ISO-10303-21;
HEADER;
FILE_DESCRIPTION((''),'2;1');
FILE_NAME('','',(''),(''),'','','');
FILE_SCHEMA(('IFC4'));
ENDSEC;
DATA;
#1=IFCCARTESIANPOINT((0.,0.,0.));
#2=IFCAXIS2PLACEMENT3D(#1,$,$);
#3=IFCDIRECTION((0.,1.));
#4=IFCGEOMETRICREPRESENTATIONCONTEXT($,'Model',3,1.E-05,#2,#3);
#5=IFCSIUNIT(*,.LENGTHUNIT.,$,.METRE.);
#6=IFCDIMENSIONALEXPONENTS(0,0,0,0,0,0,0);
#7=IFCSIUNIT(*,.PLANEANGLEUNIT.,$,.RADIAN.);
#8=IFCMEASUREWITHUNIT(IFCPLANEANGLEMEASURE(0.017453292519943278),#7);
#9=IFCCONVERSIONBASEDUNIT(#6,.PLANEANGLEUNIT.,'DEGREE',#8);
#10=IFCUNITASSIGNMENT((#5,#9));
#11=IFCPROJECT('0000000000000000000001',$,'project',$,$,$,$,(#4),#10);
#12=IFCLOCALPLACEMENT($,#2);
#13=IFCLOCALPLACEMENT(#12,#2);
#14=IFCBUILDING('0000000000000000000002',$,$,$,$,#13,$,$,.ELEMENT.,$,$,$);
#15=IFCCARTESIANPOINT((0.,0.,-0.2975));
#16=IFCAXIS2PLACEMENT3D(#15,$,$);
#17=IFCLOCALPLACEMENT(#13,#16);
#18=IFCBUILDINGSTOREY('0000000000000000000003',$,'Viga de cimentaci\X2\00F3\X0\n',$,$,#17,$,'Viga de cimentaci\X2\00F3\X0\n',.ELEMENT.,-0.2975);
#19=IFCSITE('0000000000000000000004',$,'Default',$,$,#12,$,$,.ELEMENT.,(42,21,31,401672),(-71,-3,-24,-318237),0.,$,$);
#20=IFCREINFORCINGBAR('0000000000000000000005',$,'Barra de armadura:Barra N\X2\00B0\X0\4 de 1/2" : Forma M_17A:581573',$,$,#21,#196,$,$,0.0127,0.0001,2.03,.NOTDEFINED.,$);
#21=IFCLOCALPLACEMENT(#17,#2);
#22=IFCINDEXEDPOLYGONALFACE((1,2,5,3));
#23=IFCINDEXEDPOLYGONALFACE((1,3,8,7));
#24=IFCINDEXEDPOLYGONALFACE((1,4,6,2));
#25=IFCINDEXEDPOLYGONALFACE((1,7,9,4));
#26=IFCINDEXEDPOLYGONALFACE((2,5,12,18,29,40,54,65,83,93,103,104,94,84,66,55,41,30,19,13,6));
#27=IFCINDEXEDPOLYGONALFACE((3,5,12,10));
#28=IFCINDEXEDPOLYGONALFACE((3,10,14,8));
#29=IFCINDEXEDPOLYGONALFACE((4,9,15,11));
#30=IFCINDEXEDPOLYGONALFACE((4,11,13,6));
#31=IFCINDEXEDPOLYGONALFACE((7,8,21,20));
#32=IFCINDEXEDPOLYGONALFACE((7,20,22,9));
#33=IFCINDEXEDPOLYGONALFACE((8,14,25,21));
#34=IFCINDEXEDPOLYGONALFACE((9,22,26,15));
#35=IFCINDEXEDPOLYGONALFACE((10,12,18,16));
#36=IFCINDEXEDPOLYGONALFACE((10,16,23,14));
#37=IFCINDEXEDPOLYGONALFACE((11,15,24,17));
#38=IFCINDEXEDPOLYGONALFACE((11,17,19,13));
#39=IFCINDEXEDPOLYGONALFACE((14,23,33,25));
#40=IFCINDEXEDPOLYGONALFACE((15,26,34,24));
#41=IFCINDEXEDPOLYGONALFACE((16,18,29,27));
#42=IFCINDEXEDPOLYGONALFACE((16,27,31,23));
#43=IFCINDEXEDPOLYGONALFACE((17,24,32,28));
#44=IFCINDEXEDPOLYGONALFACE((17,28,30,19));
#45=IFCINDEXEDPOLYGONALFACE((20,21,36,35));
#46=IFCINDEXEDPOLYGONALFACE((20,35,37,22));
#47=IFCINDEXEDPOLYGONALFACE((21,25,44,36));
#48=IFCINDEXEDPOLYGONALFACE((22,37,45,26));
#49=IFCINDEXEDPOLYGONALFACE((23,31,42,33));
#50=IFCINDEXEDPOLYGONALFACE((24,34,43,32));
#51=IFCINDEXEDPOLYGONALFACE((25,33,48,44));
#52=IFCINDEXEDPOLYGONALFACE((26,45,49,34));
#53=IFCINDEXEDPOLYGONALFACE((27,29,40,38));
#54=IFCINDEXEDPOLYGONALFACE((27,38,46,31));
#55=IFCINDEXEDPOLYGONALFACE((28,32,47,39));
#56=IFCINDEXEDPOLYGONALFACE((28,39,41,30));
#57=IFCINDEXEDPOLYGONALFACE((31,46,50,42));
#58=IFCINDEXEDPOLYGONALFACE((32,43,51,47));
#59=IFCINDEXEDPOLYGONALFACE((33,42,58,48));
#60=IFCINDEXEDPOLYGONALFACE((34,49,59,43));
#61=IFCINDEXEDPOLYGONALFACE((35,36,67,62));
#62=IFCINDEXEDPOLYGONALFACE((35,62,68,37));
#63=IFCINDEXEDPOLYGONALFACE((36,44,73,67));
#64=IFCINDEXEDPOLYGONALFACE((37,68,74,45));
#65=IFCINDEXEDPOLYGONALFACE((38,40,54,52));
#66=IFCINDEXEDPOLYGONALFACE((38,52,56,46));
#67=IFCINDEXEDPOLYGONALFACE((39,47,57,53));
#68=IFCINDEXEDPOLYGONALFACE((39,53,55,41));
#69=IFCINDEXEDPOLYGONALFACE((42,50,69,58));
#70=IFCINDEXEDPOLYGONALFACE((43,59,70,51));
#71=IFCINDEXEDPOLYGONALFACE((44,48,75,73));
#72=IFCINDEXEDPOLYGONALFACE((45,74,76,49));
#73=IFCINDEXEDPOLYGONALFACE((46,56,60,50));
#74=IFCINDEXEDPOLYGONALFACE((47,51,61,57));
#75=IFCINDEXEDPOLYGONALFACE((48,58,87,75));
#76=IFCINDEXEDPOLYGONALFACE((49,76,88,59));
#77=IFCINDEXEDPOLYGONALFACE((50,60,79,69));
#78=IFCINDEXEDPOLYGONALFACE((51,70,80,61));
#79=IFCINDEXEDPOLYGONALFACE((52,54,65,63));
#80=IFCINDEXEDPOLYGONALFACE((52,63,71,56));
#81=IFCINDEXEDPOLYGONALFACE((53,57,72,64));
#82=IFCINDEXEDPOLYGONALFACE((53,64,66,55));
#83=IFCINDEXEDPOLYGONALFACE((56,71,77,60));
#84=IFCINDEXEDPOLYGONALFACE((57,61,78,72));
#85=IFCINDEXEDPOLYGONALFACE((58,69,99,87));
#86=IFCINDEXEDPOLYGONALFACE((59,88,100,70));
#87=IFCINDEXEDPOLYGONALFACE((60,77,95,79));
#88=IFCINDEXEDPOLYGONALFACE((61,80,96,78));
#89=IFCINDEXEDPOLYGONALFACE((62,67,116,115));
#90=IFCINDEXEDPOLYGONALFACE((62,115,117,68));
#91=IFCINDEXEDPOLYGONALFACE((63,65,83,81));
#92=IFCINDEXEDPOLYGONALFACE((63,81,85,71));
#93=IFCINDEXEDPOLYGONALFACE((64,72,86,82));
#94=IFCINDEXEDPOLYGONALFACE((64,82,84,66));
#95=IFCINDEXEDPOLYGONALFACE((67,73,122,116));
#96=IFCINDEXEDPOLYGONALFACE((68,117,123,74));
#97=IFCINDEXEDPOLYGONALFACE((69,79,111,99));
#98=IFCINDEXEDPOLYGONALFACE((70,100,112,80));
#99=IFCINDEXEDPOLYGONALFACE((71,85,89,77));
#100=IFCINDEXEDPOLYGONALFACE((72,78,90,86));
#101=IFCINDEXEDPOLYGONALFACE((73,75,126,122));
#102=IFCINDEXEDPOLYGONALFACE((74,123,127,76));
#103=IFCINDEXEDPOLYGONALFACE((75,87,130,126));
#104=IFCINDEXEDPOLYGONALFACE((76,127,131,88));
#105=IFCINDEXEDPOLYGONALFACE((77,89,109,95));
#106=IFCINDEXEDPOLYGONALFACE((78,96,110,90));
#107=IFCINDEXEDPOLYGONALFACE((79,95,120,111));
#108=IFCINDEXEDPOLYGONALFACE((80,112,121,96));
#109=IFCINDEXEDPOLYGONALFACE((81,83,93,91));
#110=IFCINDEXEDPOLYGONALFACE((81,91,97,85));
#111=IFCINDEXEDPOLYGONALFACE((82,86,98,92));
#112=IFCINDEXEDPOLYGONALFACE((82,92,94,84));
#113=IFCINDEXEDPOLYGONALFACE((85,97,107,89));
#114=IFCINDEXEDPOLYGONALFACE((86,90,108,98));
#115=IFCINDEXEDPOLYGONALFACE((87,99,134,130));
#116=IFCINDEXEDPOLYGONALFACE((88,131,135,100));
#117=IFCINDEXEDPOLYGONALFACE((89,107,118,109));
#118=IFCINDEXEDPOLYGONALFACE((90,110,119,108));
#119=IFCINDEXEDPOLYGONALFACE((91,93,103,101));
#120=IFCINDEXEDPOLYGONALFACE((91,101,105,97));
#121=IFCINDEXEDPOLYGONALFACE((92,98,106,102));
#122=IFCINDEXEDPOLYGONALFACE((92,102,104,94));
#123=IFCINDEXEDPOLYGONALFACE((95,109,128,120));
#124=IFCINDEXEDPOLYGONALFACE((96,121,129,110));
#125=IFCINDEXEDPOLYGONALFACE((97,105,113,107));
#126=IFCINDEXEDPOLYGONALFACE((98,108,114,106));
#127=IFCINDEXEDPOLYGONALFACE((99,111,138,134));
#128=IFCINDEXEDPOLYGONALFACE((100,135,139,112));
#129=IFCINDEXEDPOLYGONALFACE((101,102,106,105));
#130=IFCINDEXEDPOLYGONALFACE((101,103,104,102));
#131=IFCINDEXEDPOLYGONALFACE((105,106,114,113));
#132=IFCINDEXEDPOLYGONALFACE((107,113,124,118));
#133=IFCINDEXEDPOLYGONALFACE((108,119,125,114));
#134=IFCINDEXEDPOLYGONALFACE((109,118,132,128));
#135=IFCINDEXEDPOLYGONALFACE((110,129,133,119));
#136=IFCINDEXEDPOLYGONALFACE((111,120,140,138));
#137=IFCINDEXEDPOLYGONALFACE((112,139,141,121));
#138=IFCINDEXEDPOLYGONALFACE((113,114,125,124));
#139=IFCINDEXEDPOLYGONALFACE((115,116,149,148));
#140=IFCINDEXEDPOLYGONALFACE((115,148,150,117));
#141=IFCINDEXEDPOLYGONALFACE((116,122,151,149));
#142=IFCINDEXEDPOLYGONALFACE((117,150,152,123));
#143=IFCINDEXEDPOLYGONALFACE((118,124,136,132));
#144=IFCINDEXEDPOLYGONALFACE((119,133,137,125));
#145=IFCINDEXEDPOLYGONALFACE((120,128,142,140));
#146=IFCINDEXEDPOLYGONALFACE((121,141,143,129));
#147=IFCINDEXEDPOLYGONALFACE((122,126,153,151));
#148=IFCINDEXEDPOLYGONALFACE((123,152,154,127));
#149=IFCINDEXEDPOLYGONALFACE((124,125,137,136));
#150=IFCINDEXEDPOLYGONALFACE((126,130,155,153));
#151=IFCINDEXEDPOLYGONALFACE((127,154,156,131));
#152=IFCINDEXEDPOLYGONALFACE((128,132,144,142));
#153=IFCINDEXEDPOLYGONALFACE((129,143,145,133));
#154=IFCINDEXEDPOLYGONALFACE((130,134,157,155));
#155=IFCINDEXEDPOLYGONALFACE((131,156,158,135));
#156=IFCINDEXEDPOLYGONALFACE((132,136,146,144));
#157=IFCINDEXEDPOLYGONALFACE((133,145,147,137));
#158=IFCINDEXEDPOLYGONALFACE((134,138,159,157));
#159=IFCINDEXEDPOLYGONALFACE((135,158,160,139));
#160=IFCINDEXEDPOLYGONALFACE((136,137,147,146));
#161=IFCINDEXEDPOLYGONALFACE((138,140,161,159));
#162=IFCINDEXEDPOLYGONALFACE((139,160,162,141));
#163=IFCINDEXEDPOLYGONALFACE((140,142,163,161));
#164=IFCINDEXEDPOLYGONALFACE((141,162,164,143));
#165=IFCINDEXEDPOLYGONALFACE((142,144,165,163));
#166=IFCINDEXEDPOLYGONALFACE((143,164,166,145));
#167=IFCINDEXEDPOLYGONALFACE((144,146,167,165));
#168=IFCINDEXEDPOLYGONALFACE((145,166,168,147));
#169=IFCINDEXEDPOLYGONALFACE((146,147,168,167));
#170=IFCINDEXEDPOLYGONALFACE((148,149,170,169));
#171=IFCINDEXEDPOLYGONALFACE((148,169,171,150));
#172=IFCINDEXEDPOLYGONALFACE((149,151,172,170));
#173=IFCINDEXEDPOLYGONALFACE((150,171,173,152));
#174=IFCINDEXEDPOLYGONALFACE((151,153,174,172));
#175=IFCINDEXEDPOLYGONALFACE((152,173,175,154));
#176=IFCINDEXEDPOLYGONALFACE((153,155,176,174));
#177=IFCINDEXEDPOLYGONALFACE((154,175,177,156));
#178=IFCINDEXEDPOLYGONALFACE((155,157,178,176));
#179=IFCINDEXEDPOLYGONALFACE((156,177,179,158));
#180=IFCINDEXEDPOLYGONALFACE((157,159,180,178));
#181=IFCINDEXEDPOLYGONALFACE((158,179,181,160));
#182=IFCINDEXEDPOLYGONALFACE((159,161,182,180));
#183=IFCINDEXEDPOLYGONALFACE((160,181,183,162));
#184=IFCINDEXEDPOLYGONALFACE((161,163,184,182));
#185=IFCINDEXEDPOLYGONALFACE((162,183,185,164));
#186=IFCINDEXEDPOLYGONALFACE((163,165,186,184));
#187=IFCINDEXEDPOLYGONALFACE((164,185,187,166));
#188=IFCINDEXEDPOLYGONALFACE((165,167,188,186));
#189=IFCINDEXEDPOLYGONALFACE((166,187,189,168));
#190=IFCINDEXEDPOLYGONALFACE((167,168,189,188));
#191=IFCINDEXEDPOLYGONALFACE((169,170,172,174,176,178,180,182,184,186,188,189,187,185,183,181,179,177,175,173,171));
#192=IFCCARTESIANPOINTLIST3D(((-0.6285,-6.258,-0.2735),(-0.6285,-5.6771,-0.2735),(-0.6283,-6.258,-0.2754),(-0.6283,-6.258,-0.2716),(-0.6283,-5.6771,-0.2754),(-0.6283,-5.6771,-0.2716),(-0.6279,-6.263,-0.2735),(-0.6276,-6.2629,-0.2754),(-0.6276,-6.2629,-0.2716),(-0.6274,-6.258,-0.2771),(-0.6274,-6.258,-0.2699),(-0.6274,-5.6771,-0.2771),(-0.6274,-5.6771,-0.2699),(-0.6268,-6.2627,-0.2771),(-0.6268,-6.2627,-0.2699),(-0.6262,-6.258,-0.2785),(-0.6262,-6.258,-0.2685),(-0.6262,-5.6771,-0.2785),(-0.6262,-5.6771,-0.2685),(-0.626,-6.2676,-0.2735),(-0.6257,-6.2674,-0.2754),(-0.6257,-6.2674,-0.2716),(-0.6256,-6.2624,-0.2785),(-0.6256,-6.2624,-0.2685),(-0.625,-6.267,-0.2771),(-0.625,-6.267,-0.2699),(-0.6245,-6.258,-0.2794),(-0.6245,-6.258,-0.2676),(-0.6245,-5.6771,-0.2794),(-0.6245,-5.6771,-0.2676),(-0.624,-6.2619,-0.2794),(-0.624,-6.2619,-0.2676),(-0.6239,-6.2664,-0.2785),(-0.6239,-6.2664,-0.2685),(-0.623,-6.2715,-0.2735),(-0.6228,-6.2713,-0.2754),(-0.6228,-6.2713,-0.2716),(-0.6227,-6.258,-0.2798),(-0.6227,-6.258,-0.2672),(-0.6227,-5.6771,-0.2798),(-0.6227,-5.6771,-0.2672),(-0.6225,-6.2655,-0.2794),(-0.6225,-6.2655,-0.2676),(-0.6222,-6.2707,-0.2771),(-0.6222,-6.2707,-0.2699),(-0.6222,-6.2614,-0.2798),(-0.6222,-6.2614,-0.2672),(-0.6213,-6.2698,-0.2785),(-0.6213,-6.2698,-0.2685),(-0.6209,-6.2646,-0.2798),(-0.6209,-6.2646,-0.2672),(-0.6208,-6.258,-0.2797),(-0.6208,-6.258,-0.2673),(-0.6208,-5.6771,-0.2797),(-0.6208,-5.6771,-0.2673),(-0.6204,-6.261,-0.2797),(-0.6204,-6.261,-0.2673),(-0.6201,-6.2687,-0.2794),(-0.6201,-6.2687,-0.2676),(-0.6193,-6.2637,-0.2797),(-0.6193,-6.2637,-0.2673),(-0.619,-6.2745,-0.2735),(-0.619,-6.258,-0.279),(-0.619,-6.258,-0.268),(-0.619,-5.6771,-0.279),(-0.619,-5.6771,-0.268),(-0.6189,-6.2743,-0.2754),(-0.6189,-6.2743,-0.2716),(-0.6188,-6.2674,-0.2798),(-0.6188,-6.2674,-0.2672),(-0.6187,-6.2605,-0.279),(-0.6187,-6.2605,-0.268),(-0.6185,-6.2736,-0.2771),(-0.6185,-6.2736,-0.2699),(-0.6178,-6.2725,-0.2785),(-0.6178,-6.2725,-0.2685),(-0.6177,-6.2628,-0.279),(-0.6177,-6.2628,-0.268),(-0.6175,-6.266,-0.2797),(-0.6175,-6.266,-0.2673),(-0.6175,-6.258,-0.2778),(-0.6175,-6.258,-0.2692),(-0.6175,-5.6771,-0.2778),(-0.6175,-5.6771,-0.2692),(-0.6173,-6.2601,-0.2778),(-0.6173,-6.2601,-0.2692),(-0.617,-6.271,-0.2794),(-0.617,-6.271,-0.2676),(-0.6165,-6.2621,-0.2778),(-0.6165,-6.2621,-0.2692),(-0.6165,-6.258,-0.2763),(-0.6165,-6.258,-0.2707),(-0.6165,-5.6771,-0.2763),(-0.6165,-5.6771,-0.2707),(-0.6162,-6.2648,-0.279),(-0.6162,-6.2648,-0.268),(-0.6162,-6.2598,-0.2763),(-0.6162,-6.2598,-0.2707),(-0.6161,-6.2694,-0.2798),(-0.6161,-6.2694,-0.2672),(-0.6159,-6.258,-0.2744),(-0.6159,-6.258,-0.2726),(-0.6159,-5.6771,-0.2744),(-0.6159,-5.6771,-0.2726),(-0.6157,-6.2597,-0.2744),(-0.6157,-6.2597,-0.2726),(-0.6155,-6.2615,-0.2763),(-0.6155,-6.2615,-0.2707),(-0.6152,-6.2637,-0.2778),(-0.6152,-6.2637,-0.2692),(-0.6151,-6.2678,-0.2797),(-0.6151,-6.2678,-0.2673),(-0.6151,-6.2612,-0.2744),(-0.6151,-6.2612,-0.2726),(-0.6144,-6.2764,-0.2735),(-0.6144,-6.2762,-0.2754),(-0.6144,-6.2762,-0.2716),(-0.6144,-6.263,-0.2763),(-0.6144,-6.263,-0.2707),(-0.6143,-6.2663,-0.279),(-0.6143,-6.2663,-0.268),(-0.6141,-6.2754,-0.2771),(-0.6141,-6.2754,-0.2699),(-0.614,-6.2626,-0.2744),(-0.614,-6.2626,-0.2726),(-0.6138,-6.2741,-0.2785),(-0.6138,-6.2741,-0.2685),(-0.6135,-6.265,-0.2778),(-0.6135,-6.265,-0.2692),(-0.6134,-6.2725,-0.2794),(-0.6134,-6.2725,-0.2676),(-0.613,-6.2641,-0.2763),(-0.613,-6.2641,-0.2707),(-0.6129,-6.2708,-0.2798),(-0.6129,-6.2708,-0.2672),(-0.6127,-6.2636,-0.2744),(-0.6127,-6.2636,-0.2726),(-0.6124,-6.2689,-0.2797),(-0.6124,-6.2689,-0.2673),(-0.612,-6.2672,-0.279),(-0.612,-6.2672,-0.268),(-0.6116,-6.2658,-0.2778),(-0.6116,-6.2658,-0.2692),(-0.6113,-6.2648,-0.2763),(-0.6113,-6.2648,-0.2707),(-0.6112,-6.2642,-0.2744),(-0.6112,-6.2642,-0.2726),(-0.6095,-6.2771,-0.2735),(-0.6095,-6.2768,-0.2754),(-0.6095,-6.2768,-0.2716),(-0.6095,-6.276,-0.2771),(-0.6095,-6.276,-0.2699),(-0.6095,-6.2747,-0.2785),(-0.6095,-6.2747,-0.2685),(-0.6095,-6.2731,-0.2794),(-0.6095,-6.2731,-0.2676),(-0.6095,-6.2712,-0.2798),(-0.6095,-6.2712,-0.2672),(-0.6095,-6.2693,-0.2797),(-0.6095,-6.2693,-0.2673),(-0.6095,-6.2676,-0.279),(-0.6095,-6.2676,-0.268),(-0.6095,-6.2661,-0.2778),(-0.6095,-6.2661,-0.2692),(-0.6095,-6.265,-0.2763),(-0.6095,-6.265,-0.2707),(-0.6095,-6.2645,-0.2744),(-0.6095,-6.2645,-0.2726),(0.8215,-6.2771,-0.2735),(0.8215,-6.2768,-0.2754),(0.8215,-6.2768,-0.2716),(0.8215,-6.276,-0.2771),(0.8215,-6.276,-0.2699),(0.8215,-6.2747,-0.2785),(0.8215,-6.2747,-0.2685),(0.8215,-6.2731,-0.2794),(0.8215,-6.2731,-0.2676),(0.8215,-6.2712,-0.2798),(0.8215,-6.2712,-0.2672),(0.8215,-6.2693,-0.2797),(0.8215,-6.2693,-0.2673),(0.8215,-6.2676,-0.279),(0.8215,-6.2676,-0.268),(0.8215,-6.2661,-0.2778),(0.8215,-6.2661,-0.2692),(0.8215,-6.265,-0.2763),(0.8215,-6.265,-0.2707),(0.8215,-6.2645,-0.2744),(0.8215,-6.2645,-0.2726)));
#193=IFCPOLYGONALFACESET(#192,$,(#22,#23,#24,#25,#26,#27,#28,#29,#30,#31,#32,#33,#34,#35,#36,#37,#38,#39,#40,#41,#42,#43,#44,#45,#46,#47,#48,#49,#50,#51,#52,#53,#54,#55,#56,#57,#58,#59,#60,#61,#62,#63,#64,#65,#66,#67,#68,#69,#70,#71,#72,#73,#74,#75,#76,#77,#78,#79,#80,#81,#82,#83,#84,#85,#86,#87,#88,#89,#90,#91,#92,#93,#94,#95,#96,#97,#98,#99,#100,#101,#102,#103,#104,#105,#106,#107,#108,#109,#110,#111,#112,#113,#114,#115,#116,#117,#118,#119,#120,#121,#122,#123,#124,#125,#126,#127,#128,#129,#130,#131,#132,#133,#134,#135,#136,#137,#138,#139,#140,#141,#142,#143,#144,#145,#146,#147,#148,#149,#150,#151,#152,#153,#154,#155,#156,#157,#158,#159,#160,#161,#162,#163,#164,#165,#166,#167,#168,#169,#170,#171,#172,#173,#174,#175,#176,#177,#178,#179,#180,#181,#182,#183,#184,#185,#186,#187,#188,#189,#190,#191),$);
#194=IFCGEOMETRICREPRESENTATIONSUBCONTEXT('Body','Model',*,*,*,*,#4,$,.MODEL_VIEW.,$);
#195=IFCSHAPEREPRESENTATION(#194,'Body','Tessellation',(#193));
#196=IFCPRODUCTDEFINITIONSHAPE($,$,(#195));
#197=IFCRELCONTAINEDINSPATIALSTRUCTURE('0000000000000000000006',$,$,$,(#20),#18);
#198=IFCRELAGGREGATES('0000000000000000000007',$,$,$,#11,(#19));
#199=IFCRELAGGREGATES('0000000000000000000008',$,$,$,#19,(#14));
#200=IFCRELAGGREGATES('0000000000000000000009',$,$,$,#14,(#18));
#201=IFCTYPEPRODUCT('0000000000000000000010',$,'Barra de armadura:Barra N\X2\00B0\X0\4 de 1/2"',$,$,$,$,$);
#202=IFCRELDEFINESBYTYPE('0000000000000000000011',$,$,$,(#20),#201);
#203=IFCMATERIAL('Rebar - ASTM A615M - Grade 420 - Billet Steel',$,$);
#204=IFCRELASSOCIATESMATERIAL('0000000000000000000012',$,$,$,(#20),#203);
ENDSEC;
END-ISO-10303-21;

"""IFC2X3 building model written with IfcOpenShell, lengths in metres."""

from ifc_helpers import new_model, entity, si_unit, converted_unit, direction, frame, origin, place, context, subcontext, project, spatial, material, type_object, element, save


model = new_model("IFC2X3")

# Units and contexts
model_context = context("Model", 3, precision=1e-05, world=origin(), true_north=direction((0.0, 1.0)))
body_context = subcontext(model_context, "Body", "Model", "MODEL_VIEW")
ifc_project = project(units=[si_unit("LENGTHUNIT", "METRE"), converted_unit("PLANEANGLEUNIT", "DEGREE", entity("IfcPlaneAngleMeasure", 0.017453292519943278), si_unit("PLANEANGLEUNIT", "RADIAN"), dimensions=[0, 0, 0, 0, 0, 0, 0])], contexts=[model_context])

# Site, building, storey
site_placement = place(None, origin())
site = spatial("IfcSite", under=ifc_project, at=site_placement, Name="Default", CompositionType="ELEMENT", RefLatitude=(42, 21, 31, 401672), RefLongitude=(-71, -3, -24, -318237), RefElevation=0.0)
building_placement = place(site_placement, origin())
building = spatial("IfcBuilding", under=site, at=building_placement, CompositionType="ELEMENT")
storey_placement = place(building_placement, frame((0.0, 0.0, -0.2975)))
storey = spatial("IfcBuildingStorey", under=building, at=storey_placement, Name="Viga de cimentación", LongName="Viga de cimentación", CompositionType="ELEMENT", Elevation=-0.2975)

# Reinforcing bar
ifc_material = material(Name="Rebar - ASTM A615M - Grade 420 - Billet Steel")
type_product_1 = type_object("IfcTypeProduct", Name="Barra de armadura:Barra N°4 de 1/2\"")
reinforcing_bar_1_placement = place(storey_placement, origin())
element("IfcReinforcingBar", 1, at=reinforcing_bar_1_placement, inside=storey, type_object=type_product_1, material=ifc_material, Name="Barra de armadura:Barra N°4 de 1/2\" : Forma M_17A:581573", BarLength=2.03, BarRole="NOTDEFINED", CrossSectionArea=0.0001, NominalDiameter=0.0127, context=body_context, shape_type="AdvancedSweptSolid", body=[
    entity("IfcSweptDiskSolid", entity("IfcCompositeCurve", [entity("IfcCompositeCurveSegment", "CONTINUOUS", True, entity("IfcPolyline", [entity("IfcCartesianPoint", [-0.6222, -5.6771, -0.2735]), entity("IfcCartesianPoint", [-0.6222, -6.258, -0.2735])])), entity("IfcCompositeCurveSegment", "CONTINUOUS", True, entity("IfcTrimmedCurve", entity("IfcCircle", entity("IfcAxis2Placement3D", entity("IfcCartesianPoint", [-0.6095, -6.258, -0.2735]), entity("IfcDirection", [0.0, 0.0, 1.0]), entity("IfcDirection", [0.0, -1.0, 0.0])), 0.0127), [entity("IfcParameterValue", 270.0)], [entity("IfcParameterValue", 360.0)], True, "PARAMETER")), entity("IfcCompositeCurveSegment", "CONTINUOUS", True, entity("IfcPolyline", [entity("IfcCartesianPoint", [-0.6095, -6.2707, -0.2735]), entity("IfcCartesianPoint", [0.8215, -6.2707, -0.2735])]))], False), 0.0063, None, 0.0, 92.0),
])

save(model, "model.ifc")
